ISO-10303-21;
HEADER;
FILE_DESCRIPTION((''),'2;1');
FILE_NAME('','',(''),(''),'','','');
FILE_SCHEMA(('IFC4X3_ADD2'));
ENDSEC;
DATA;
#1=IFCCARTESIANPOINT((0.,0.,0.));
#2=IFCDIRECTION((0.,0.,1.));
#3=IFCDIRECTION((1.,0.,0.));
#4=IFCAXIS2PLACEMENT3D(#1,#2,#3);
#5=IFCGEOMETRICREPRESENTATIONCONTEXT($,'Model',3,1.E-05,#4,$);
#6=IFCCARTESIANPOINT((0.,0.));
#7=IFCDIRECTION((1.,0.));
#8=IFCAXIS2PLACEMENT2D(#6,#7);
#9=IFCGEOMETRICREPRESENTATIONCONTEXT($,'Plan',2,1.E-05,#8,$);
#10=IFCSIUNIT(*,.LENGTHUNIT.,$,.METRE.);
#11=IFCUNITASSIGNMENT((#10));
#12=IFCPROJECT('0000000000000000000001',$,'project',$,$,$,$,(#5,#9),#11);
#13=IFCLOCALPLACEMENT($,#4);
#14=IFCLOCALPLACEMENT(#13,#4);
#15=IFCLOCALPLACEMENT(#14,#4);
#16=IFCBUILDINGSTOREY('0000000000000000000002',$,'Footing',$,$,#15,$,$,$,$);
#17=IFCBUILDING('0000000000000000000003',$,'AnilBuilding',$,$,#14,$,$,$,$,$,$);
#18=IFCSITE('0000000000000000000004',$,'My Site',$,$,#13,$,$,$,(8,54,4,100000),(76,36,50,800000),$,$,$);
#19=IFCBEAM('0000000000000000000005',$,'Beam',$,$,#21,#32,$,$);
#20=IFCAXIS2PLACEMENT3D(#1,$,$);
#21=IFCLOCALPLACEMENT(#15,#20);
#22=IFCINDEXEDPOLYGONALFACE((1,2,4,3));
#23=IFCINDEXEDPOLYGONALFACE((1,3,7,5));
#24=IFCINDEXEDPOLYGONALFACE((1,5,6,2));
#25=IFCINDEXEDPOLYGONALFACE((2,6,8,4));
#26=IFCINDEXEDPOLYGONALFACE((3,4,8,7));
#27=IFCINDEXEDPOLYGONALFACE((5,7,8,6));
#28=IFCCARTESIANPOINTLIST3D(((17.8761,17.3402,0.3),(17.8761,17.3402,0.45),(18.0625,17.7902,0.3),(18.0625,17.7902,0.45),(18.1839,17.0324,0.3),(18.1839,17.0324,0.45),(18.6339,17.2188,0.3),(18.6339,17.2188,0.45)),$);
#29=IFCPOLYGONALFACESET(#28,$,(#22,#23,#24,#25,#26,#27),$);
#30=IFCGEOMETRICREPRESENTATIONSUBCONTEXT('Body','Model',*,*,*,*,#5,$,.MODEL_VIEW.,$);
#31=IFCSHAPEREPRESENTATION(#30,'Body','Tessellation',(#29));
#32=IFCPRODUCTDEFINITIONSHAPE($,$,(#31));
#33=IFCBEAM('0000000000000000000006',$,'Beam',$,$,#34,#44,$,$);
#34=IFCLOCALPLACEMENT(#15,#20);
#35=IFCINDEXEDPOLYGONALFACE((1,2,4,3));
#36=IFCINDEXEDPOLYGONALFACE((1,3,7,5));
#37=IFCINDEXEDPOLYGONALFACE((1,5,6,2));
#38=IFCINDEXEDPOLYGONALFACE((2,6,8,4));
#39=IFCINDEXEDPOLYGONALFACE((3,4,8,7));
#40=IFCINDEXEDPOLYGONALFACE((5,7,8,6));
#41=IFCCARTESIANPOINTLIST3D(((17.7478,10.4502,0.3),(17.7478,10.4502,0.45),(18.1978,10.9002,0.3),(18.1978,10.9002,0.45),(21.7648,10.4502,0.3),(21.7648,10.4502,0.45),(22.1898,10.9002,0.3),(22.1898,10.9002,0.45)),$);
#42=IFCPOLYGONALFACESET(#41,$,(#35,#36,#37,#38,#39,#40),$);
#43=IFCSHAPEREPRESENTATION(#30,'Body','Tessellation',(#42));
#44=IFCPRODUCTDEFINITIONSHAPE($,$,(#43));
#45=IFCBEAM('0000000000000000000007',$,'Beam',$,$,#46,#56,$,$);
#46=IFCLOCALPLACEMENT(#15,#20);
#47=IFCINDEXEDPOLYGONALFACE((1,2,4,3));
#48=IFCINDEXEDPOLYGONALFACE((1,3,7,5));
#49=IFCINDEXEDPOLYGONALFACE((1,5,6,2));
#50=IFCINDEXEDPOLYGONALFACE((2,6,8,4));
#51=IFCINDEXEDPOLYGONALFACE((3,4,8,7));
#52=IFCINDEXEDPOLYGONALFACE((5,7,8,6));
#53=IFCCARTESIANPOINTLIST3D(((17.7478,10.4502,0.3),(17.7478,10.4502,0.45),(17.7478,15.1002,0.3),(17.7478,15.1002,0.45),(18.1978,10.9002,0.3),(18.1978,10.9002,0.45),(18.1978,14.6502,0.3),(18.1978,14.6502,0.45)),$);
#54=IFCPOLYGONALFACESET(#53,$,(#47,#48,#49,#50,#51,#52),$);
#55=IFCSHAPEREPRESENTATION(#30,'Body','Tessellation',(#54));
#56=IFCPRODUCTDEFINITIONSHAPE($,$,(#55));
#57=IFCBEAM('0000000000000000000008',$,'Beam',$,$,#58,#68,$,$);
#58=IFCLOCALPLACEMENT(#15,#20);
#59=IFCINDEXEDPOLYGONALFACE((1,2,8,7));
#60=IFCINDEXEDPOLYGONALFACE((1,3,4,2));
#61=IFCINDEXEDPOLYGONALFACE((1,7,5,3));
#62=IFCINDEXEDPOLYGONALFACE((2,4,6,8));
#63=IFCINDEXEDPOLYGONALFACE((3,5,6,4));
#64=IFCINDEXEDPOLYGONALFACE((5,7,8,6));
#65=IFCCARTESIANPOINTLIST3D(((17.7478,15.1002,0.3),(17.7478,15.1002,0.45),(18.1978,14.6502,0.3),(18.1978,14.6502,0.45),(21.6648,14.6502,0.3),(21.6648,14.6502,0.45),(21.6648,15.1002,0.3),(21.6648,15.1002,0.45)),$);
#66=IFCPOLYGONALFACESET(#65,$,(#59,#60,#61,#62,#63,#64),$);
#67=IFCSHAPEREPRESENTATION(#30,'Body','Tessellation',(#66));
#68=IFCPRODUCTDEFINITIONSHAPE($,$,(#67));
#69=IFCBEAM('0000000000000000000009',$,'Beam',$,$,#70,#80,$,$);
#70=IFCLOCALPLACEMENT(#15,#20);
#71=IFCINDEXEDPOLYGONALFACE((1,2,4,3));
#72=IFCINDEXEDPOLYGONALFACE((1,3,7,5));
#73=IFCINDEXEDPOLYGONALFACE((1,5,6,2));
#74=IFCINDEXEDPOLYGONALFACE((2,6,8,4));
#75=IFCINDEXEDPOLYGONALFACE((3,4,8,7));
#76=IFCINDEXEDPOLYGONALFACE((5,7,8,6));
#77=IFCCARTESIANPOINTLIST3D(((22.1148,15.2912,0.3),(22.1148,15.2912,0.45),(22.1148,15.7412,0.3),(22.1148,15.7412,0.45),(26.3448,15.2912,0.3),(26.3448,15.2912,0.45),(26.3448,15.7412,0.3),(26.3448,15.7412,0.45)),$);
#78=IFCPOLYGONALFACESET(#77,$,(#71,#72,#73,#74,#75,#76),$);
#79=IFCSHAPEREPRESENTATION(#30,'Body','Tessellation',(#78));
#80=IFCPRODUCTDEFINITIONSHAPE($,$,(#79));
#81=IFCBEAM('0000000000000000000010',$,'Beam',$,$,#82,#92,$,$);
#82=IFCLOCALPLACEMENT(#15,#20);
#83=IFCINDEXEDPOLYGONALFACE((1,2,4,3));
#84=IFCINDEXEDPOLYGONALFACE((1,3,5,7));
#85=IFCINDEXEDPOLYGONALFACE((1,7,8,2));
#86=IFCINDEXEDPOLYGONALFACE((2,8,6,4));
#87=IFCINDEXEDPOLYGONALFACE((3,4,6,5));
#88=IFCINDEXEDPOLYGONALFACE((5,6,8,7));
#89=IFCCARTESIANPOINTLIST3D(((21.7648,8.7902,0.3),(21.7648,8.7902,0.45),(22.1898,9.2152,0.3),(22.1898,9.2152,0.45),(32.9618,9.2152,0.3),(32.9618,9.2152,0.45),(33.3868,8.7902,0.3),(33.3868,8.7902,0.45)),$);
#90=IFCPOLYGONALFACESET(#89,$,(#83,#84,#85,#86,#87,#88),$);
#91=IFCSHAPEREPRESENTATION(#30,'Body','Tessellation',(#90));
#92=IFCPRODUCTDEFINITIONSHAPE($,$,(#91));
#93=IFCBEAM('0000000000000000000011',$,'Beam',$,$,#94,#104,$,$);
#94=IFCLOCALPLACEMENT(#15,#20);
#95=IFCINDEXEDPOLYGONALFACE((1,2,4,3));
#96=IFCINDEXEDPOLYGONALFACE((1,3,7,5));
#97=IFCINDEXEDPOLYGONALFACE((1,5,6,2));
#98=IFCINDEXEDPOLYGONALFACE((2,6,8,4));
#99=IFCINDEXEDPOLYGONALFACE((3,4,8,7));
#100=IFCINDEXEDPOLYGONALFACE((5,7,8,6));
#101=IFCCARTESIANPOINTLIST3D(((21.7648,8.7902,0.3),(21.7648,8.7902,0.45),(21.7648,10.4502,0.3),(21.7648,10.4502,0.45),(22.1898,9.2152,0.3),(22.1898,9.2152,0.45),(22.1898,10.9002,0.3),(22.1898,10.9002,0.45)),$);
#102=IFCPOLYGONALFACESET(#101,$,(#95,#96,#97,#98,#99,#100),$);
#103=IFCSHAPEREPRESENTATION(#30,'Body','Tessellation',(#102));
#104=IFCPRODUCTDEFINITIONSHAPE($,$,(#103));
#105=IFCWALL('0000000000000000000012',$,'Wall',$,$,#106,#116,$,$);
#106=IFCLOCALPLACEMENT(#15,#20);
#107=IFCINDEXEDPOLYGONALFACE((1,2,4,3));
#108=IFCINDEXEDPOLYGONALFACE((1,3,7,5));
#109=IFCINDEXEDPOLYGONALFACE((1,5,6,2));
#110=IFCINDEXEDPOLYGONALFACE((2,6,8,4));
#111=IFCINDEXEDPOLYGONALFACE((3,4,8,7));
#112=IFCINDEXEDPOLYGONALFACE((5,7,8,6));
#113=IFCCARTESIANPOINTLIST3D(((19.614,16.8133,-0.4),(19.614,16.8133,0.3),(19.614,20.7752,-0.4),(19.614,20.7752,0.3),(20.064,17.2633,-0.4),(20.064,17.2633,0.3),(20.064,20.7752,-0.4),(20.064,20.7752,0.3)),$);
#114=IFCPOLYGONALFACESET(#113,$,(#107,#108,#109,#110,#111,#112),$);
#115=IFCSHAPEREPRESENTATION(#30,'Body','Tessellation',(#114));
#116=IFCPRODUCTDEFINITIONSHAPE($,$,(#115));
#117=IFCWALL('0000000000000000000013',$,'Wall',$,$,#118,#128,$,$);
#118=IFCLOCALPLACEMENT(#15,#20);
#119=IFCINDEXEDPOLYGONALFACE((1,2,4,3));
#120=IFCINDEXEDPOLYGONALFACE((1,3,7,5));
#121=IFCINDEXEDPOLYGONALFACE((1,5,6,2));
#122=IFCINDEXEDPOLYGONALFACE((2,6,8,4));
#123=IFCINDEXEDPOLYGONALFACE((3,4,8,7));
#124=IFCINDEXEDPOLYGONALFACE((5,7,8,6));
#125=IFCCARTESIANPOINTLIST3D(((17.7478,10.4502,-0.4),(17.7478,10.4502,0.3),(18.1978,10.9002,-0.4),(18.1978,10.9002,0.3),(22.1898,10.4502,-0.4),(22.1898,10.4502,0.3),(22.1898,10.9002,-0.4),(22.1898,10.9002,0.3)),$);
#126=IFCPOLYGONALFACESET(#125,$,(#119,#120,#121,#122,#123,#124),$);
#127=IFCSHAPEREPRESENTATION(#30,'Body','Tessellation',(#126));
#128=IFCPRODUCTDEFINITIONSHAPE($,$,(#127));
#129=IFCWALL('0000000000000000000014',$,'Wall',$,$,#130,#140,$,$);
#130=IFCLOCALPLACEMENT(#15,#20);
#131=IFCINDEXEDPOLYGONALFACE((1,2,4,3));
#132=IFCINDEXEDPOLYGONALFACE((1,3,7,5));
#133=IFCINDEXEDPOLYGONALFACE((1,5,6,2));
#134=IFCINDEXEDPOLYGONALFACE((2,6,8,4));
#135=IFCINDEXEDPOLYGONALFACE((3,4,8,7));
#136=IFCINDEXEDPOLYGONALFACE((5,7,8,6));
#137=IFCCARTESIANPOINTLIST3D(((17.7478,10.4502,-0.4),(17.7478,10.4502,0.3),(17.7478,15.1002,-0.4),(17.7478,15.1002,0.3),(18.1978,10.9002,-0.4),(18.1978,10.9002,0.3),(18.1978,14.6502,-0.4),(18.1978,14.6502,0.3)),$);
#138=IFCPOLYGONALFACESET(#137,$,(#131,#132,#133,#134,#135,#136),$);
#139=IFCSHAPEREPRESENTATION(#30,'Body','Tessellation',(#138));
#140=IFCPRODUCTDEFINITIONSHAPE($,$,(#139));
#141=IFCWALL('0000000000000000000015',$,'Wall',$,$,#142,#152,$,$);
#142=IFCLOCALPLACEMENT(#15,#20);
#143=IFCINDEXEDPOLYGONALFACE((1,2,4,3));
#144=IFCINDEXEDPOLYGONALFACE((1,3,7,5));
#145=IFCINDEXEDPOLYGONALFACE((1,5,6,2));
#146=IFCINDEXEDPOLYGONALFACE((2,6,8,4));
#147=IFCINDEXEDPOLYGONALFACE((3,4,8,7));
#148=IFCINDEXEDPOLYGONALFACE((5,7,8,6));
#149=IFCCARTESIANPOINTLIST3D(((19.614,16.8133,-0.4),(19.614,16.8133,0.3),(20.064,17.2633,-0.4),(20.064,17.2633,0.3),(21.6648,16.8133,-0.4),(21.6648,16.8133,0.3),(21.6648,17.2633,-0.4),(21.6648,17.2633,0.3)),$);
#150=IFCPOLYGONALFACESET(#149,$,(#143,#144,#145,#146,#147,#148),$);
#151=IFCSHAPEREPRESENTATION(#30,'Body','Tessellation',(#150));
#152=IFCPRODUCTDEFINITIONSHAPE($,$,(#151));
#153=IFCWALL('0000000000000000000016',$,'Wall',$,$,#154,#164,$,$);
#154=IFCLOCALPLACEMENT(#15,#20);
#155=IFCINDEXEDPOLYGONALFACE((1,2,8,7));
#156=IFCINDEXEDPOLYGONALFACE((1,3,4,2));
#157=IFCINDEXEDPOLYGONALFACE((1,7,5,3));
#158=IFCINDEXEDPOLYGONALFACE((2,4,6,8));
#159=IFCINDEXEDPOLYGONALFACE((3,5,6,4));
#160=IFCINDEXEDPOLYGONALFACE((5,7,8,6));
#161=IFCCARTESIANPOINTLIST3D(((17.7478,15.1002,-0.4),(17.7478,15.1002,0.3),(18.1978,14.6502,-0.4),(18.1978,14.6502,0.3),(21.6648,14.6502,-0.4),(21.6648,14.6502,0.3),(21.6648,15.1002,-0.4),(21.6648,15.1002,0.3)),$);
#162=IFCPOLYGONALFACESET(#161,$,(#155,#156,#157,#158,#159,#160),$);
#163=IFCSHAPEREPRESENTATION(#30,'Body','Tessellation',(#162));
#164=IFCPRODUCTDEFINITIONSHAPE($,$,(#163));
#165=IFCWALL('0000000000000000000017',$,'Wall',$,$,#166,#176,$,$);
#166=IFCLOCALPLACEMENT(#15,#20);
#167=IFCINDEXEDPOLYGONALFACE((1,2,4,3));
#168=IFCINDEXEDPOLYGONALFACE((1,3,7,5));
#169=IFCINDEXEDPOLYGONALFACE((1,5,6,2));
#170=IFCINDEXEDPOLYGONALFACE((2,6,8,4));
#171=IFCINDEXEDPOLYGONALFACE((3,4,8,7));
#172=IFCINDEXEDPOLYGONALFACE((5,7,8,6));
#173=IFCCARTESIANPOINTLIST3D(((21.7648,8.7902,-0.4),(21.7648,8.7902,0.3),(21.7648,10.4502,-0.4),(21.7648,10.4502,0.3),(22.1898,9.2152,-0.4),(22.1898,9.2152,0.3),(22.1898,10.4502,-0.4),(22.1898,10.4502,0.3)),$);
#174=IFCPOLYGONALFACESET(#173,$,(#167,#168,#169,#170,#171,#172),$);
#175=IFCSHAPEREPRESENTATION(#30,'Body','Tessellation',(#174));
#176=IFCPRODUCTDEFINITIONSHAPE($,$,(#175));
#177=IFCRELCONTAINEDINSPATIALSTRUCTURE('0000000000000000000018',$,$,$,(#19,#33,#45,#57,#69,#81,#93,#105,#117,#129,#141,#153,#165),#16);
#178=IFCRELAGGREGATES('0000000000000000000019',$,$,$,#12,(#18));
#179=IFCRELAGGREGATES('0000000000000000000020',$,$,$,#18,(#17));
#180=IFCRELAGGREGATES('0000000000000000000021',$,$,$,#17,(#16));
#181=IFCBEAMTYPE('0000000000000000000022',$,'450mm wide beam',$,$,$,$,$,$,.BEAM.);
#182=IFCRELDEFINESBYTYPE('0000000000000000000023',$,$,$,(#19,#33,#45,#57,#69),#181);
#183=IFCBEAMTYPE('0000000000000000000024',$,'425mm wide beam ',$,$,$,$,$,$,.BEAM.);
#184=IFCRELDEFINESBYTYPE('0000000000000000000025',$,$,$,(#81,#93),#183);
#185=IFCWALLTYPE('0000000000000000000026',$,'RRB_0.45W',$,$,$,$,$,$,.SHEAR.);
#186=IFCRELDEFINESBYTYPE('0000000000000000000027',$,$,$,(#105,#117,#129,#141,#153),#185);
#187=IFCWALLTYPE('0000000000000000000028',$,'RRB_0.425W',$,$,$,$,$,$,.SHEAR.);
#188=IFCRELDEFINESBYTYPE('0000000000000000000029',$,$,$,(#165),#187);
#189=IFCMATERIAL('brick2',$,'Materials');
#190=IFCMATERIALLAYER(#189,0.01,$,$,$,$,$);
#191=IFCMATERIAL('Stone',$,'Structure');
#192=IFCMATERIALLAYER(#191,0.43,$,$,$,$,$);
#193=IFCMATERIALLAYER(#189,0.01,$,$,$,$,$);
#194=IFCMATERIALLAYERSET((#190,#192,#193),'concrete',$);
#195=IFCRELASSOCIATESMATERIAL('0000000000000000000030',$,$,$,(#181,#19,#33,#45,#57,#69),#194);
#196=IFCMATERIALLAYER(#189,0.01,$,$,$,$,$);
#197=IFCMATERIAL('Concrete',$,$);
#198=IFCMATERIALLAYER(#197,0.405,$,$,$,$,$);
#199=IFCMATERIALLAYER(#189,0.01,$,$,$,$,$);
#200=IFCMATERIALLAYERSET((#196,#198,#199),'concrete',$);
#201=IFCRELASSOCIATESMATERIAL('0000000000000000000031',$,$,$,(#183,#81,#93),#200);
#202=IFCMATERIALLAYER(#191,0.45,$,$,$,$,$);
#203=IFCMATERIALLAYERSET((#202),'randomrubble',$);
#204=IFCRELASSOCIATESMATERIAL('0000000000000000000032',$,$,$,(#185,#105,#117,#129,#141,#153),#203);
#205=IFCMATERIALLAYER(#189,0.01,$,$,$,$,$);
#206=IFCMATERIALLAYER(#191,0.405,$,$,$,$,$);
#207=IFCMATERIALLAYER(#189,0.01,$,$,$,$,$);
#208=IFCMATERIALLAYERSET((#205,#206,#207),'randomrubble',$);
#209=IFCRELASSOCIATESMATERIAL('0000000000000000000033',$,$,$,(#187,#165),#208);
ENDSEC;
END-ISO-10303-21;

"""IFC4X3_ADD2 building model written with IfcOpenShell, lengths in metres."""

from ifc_helpers import new_model, si_unit, frame, origin_with_axes, origin_2d_with_axis, place, context, subcontext, project, spatial, line, indexed_curve, outline, extrude, material, layer, layer_set, layer_usage, type_object, element, save


model = new_model("IFC4X3_ADD2")

# Units and contexts
model_context = context("Model", 3, precision=1e-05, world=origin_with_axes())
plan_context = context("Plan", 2, precision=1e-05, world=origin_2d_with_axis())
body_context = subcontext(model_context, "Body", "Model", "MODEL_VIEW")
ifc_project = project(units=[si_unit("LENGTHUNIT", "METRE")], contexts=[model_context, plan_context])

# Site, building, storey
site_placement = place(None, origin_with_axes())
site = spatial("IfcSite", under=ifc_project, at=site_placement, Name="My Site", RefLatitude=(8, 54, 4, 100000), RefLongitude=(76, 36, 50, 800000))
building_placement = place(site_placement, origin_with_axes())
building = spatial("IfcBuilding", under=site, at=building_placement, Name="AnilBuilding")
storey_placement = place(building_placement, origin_with_axes())
storey = spatial("IfcBuildingStorey", under=building, at=storey_placement, Name="Footing")

# Beams
ifc_material_1 = material(Name="brick2", Category="Materials")
ifc_layer_1 = layer(ifc_material_1, 0.01)
ifc_material_2 = material(Name="Stone", Category="Structure")
ifc_layer_2 = layer(ifc_material_2, 0.43)
ifc_layer_3 = layer(ifc_material_1, 0.01)
ifc_layer_set_1 = layer_set([ifc_layer_1, ifc_layer_2, ifc_layer_3], Name="concrete")
ifc_layer_usage_1 = layer_usage(ifc_layer_set_1, "AXIS2", "NEGATIVE", 0.0)
beam_type_1 = type_object("IfcBeamType", Name="450mm wide beam", PredefinedType="BEAM", material=ifc_layer_set_1)
beam_1_placement = place(storey_placement, frame((18.1839, 17.0324, 0.3), z_axis=(0.0, 0.0, 1.0), x_axis=(-0.707107, 0.707107, 0.0)))
element("IfcBeam", 1, at=beam_1_placement, inside=storey, type_object=beam_type_1, material=ifc_layer_usage_1, Name="Beam", context=body_context, shape_type="SweptSolid", body=[
    extrude(outline(indexed_curve([(-0.1864, -0.45), (0.0, 0.0), (0.4353, 0.0), (0.6217, -0.45)], segments=[line(1, 2, 3, 4, 1)])), origin_with_axes(), (0.0, 0.0, 1.0), 0.15),
])
ifc_layer_usage_2 = layer_usage(ifc_layer_set_1, "AXIS2", "POSITIVE", 0.0)
beam_2_placement = place(storey_placement, frame((18.1978, 10.4502, 0.3), z_axis=(0.0, 0.0, 1.0), x_axis=(1.0, 0.0, 0.0)))
element("IfcBeam", 2, at=beam_2_placement, inside=storey, type_object=beam_type_1, material=ifc_layer_usage_2, Name="Beam", context=body_context, shape_type="SweptSolid", body=[
    extrude(outline(indexed_curve([(-0.45, 0.0), (0.0, 0.45), (3.992, 0.45), (3.567, 0.0)], segments=[line(1, 2, 3, 4, 1)])), origin_with_axes(), (0.0, 0.0, 1.0), 0.15),
])
ifc_layer_usage_3 = layer_usage(ifc_layer_set_1, "AXIS2", "NEGATIVE", 0.0)
beam_3_placement = place(storey_placement, frame((18.1978, 15.1002, 0.3), z_axis=(0.0, 0.0, 1.0), x_axis=(0.0, -1.0, 0.0)))
element("IfcBeam", 3, at=beam_3_placement, inside=storey, type_object=beam_type_1, material=ifc_layer_usage_3, Name="Beam", context=body_context, shape_type="SweptSolid", body=[
    extrude(outline(indexed_curve([(0.0, -0.45), (0.45, 0.0), (4.2, 0.0), (4.65, -0.45)], segments=[line(1, 2, 3, 4, 1)])), origin_with_axes(), (0.0, 0.0, 1.0), 0.15),
])
ifc_layer_usage_4 = layer_usage(ifc_layer_set_1, "AXIS2", "NEGATIVE", 0.0)
beam_4_placement = place(storey_placement, frame((18.1978, 15.1002, 0.3), z_axis=(0.0, 0.0, 1.0), x_axis=(1.0, 0.0, 0.0)))
element("IfcBeam", 4, at=beam_4_placement, inside=storey, type_object=beam_type_1, material=ifc_layer_usage_4, Name="Beam", context=body_context, shape_type="SweptSolid", body=[
    extrude(outline(indexed_curve([(0.0, -0.45), (-0.45, 0.0), (3.467, 0.0), (3.467, -0.45)], segments=[line(1, 2, 3, 4, 1)])), origin_with_axes(), (0.0, 0.0, 1.0), 0.15),
])
ifc_layer_usage_5 = layer_usage(ifc_layer_set_1, "AXIS2", "NEGATIVE", 0.0)
beam_5_placement = place(storey_placement, frame((22.1148, 15.7412, 0.3), z_axis=(0.0, 0.0, 1.0), x_axis=(1.0, 0.0, 0.0)))
element("IfcBeam", 5, at=beam_5_placement, inside=storey, type_object=beam_type_1, material=ifc_layer_usage_5, Name="Beam", context=body_context, shape_type="SweptSolid", body=[
    extrude(outline(indexed_curve([(0.0, -0.45), (0.0, 0.0), (4.23, 0.0), (4.23, -0.45)], segments=[line(1, 2, 3, 4, 1)])), origin_with_axes(), (0.0, 0.0, 1.0), 0.15),
])
ifc_layer_4 = layer(ifc_material_1, 0.01)
ifc_material_3 = material(Name="Concrete")
ifc_layer_5 = layer(ifc_material_3, 0.405)
ifc_layer_6 = layer(ifc_material_1, 0.01)
ifc_layer_set_2 = layer_set([ifc_layer_4, ifc_layer_5, ifc_layer_6], Name="concrete")
ifc_layer_usage_6 = layer_usage(ifc_layer_set_2, "AXIS2", "POSITIVE", 0.0)
beam_type_2 = type_object("IfcBeamType", Name="425mm wide beam ", PredefinedType="BEAM", material=ifc_layer_set_2)
beam_6_placement = place(storey_placement, frame((22.1898, 8.7902, 0.3), z_axis=(0.0, 0.0, 1.0), x_axis=(1.0, 0.0, 0.0)))
element("IfcBeam", 6, at=beam_6_placement, inside=storey, type_object=beam_type_2, material=ifc_layer_usage_6, Name="Beam", context=body_context, shape_type="SweptSolid", body=[
    extrude(outline(indexed_curve([(-0.425, 0.0), (0.0, 0.425), (10.772, 0.425), (11.197, 0.0)], segments=[line(1, 2, 3, 4, 1)])), origin_with_axes(), (0.0, 0.0, 1.0), 0.15),
])
ifc_layer_usage_7 = layer_usage(ifc_layer_set_2, "AXIS2", "NEGATIVE", 0.0)
beam_7_placement = place(storey_placement, frame((22.1898, 10.4502, 0.3), z_axis=(0.0, 0.0, 1.0), x_axis=(0.0, -1.0, 0.0)))
element("IfcBeam", 7, at=beam_7_placement, inside=storey, type_object=beam_type_2, material=ifc_layer_usage_7, Name="Beam", context=body_context, shape_type="SweptSolid", body=[
    extrude(outline(indexed_curve([(0.0, -0.425), (-0.45, 0.0), (1.235, 0.0), (1.66, -0.425)], segments=[line(1, 2, 3, 4, 1)])), origin_with_axes(), (0.0, 0.0, 1.0), 0.15),
])

# Walls
ifc_layer_7 = layer(ifc_material_2, 0.45)
ifc_layer_set_3 = layer_set([ifc_layer_7], Name="randomrubble")
ifc_layer_usage_8 = layer_usage(ifc_layer_set_3, "AXIS2", "NEGATIVE", 0.0)
wall_type_1 = type_object("IfcWallType", Name="RRB_0.45W", PredefinedType="SHEAR", material=ifc_layer_set_3)
wall_1_placement = place(storey_placement, frame((19.614, 16.8133, -0.4), z_axis=(0.0, 0.0, 1.0), x_axis=(0.0, 1.0, 0.0)))
element("IfcWall", 8, at=wall_1_placement, inside=storey, type_object=wall_type_1, material=ifc_layer_usage_8, Name="Wall", context=body_context, shape_type="SweptSolid", body=[
    extrude(outline(indexed_curve([(0.45, -0.45), (0.0, 0.0), (3.9619, 0.0), (3.9619, -0.45)], segments=[line(1, 2, 3, 4, 1)])), origin_with_axes(), (0.0, 0.0, 1.0), 0.7),
])
ifc_layer_usage_9 = layer_usage(ifc_layer_set_3, "AXIS2", "POSITIVE", 0.0)
wall_2_placement = place(storey_placement, frame((18.1978, 10.4502, -0.4), z_axis=(0.0, 0.0, 1.0), x_axis=(1.0, 0.0, 0.0)))
element("IfcWall", 9, at=wall_2_placement, inside=storey, type_object=wall_type_1, material=ifc_layer_usage_9, Name="Wall", context=body_context, shape_type="SweptSolid", body=[
    extrude(outline(indexed_curve([(-0.45, 0.0), (0.0, 0.45), (3.992, 0.45), (3.992, 0.0)], segments=[line(1, 2, 3, 4, 1)])), origin_with_axes(), (0.0, 0.0, 1.0), 0.7),
])
ifc_layer_usage_10 = layer_usage(ifc_layer_set_3, "AXIS2", "POSITIVE", 0.0)
wall_3_placement = place(storey_placement, frame((18.1978, 10.4502, -0.4), z_axis=(0.0, 0.0, 1.0), x_axis=(0.000001, 1.0, 0.0)))
element("IfcWall", 10, at=wall_3_placement, inside=storey, type_object=wall_type_1, material=ifc_layer_usage_10, Name="Wall", context=body_context, shape_type="SweptSolid", body=[
    extrude(outline(indexed_curve([(0.45, 0.0), (0.0, 0.45), (4.65, 0.45), (4.2, 0.0)], segments=[line(1, 2, 3, 4, 1)])), origin_with_axes(), (0.0, 0.0, 1.0), 0.7),
])
ifc_layer_usage_11 = layer_usage(ifc_layer_set_3, "AXIS2", "POSITIVE", 0.0)
wall_4_placement = place(storey_placement, frame((19.614, 16.8133, -0.4), z_axis=(0.0, 0.0, 1.0), x_axis=(1.0, 0.0, 0.0)))
element("IfcWall", 11, at=wall_4_placement, inside=storey, type_object=wall_type_1, material=ifc_layer_usage_11, Name="Wall", context=body_context, shape_type="SweptSolid", body=[
    extrude(outline(indexed_curve([(0.0, 0.0), (0.45, 0.45), (2.0508, 0.45), (2.0508, 0.0)], segments=[line(1, 2, 3, 4, 1)])), origin_with_axes(), (0.0, 0.0, 1.0), 0.7),
])
ifc_layer_usage_12 = layer_usage(ifc_layer_set_3, "AXIS2", "POSITIVE", 0.0)
wall_5_placement = place(storey_placement, frame((18.1978, 14.6502, -0.4), z_axis=(0.0, 0.0, 1.0), x_axis=(1.0, 0.0, 0.0)))
element("IfcWall", 12, at=wall_5_placement, inside=storey, type_object=wall_type_1, material=ifc_layer_usage_12, Name="Wall", context=body_context, shape_type="SweptSolid", body=[
    extrude(outline(indexed_curve([(0.0, 0.0), (-0.45, 0.45), (3.467, 0.45), (3.467, 0.0)], segments=[line(1, 2, 3, 4, 1)])), origin_with_axes(), (0.0, 0.0, 1.0), 0.7),
])
ifc_layer_8 = layer(ifc_material_1, 0.01)
ifc_layer_9 = layer(ifc_material_2, 0.405)
ifc_layer_10 = layer(ifc_material_1, 0.01)
ifc_layer_set_4 = layer_set([ifc_layer_8, ifc_layer_9, ifc_layer_10], Name="randomrubble")
ifc_layer_usage_13 = layer_usage(ifc_layer_set_4, "AXIS2", "POSITIVE", 0.0)
wall_type_2 = type_object("IfcWallType", Name="RRB_0.425W", PredefinedType="SHEAR", material=ifc_layer_set_4)
wall_6_placement = place(storey_placement, frame((22.1898, 8.7902, -0.4), z_axis=(0.0, 0.0, 1.0), x_axis=(0.0, 1.0, 0.0)))
element("IfcWall", 13, at=wall_6_placement, inside=storey, type_object=wall_type_2, material=ifc_layer_usage_13, Name="Wall", context=body_context, shape_type="SweptSolid", body=[
    extrude(outline(indexed_curve([(0.425, 0.0), (0.0, 0.425), (1.66, 0.425), (1.66, 0.0)], segments=[line(1, 2, 3, 4, 1)])), origin_with_axes(), (0.0, 0.0, 1.0), 0.7),
])

save(model, "model.ifc")
